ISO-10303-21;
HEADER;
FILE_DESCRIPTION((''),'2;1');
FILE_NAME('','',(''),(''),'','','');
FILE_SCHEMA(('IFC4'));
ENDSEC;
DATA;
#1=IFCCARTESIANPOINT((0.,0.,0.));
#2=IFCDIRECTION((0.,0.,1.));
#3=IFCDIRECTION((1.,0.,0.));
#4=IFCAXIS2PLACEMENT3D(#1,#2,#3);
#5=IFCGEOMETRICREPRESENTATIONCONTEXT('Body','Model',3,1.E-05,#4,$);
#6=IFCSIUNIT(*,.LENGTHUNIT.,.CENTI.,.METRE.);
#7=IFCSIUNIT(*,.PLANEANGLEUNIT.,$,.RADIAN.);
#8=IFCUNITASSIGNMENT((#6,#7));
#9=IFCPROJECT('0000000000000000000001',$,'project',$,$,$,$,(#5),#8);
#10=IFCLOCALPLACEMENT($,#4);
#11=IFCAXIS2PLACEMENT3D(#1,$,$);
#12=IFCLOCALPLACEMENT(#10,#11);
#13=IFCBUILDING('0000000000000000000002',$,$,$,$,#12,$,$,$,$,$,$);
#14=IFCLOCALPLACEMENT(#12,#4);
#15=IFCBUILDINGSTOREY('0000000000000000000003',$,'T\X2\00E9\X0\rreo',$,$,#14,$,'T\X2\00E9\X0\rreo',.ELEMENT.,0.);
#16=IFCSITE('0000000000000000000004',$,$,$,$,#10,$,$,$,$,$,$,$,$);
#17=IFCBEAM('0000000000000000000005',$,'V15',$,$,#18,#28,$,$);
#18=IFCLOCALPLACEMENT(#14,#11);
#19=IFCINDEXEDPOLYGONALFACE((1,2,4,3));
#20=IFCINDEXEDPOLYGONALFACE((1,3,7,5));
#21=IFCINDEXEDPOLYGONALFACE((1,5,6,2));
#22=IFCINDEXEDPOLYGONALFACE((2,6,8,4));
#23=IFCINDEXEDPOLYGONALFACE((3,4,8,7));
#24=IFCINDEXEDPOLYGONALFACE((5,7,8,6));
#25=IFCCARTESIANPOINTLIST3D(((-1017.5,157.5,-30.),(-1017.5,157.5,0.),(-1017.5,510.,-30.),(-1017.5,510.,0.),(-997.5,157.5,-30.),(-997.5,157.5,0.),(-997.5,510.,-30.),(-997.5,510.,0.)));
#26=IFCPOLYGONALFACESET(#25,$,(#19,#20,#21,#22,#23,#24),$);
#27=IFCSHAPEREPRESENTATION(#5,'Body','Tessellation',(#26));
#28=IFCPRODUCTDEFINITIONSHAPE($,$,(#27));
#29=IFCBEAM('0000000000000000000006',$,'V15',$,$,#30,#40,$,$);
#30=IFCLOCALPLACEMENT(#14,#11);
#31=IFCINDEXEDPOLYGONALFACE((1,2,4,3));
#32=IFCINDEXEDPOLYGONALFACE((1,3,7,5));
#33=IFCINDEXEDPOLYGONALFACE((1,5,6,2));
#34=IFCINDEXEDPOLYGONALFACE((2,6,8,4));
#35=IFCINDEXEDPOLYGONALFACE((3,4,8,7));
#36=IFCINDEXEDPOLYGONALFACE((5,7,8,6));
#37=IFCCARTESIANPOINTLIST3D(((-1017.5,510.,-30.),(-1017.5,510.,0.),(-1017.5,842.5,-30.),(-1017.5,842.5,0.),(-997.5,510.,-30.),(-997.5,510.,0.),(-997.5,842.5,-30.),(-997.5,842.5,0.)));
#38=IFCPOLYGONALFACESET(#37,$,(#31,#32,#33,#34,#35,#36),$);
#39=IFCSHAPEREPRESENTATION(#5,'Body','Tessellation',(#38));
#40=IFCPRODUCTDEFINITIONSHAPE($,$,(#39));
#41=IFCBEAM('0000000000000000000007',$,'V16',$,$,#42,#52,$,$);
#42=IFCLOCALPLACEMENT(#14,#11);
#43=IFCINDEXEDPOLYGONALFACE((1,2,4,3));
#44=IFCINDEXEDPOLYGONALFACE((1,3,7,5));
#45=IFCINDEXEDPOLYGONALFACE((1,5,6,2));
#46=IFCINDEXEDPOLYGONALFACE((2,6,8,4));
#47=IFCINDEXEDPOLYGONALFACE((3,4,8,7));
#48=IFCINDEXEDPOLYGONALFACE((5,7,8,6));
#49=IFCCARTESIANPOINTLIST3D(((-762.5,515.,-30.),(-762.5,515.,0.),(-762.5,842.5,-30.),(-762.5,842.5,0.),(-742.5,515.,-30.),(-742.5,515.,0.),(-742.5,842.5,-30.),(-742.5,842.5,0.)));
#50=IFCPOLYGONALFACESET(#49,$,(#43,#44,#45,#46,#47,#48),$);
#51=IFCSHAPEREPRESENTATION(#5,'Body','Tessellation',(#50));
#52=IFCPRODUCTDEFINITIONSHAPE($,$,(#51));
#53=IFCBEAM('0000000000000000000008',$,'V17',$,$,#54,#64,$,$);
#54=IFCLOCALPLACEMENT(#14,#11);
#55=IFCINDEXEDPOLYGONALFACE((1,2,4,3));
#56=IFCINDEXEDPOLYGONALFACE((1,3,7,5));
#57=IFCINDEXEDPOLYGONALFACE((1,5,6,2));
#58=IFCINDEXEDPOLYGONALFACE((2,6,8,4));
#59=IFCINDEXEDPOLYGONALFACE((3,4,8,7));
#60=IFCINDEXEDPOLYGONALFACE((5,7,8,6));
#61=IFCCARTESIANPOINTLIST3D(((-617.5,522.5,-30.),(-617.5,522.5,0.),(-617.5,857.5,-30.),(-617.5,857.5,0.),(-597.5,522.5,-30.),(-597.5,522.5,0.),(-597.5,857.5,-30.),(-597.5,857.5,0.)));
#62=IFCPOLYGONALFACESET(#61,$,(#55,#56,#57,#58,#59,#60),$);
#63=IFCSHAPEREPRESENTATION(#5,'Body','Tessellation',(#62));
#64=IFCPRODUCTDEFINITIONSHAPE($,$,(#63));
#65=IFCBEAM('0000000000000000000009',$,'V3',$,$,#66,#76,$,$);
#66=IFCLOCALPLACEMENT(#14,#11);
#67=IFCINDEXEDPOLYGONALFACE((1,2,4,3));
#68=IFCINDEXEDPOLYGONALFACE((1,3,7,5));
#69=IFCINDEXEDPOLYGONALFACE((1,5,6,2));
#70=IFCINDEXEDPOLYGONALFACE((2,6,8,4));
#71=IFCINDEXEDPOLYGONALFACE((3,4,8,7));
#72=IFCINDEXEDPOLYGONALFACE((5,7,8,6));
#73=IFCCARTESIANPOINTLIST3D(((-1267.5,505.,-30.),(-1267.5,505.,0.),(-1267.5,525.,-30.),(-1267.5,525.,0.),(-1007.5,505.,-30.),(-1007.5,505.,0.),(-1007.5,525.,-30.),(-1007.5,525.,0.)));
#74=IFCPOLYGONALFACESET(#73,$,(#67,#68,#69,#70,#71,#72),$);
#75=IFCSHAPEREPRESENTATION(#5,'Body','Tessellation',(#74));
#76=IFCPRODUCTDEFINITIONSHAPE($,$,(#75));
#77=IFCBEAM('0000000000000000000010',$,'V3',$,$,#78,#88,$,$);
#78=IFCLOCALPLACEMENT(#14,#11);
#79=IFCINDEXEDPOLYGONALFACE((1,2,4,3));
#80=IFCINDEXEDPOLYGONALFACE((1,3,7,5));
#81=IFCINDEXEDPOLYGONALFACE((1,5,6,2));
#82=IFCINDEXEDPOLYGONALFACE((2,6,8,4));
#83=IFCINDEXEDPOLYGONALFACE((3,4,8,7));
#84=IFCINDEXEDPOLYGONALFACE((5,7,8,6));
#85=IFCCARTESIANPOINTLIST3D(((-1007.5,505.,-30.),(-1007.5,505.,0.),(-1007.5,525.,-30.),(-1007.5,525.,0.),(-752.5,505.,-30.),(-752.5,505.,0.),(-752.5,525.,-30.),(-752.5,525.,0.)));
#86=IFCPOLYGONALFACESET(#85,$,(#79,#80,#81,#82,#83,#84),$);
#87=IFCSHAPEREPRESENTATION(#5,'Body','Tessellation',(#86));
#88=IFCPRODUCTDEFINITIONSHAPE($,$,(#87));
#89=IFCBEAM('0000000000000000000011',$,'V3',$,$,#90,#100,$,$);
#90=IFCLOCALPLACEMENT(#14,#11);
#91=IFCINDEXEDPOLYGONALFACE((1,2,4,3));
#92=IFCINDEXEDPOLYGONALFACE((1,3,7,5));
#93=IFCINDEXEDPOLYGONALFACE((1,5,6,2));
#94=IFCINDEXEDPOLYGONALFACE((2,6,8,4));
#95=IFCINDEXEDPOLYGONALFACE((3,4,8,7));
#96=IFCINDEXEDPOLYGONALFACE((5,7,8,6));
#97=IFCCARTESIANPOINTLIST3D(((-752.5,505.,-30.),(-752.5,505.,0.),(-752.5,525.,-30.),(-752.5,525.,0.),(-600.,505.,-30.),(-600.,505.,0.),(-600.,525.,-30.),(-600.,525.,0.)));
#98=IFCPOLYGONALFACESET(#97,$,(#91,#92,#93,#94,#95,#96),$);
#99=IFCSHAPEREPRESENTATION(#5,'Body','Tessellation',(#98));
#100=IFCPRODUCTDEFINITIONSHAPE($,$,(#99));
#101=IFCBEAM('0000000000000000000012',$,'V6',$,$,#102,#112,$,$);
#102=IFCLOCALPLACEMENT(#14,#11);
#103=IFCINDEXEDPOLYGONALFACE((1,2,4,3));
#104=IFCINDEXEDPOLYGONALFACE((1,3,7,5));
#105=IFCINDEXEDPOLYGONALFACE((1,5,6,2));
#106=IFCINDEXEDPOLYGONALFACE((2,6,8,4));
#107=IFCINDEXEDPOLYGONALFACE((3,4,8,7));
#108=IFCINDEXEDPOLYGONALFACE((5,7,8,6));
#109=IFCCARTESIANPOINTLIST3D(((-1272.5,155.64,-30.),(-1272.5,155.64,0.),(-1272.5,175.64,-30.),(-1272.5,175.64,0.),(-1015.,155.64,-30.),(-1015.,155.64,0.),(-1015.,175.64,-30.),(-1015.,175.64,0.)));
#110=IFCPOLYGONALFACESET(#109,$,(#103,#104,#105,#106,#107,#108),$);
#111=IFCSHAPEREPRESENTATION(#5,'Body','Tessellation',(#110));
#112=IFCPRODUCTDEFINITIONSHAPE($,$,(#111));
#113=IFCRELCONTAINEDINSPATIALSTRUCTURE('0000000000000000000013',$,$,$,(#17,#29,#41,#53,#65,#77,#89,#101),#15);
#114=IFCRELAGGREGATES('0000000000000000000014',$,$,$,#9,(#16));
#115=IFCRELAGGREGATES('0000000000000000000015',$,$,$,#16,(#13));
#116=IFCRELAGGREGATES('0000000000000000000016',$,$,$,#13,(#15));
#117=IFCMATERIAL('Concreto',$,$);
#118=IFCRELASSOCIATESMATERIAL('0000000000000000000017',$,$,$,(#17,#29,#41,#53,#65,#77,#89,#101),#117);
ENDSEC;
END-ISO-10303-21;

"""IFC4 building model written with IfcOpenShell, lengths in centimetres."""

from ifc_helpers import new_model, si_unit, frame, origin, origin_with_axes, origin_2d_with_axis, place, context, project, spatial, rectangle, extrude, material, element, save


model = new_model("IFC4")

# Units and contexts
model_context = context("Model", 3, precision=1e-05, world=origin_with_axes(), identifier="Body")
ifc_project = project(units=[si_unit("LENGTHUNIT", "METRE", prefix="CENTI"), si_unit("PLANEANGLEUNIT", "RADIAN")], contexts=[model_context])

# Site, building, storey
site_placement = place(None, origin_with_axes())
site = spatial("IfcSite", under=ifc_project, at=site_placement)
building_placement = place(site_placement, origin())
building = spatial("IfcBuilding", under=site, at=building_placement)
storey_placement = place(building_placement, origin_with_axes())
storey = spatial("IfcBuildingStorey", under=building, at=storey_placement, Name="Térreo", LongName="Térreo", CompositionType="ELEMENT", Elevation=0.0)

# Shared definitions
ifc_material = material(Name="Concreto")

# Beams
beam_1_placement = place(storey_placement, frame((-1007.5, 333.75, 0.0), z_axis=(0.0, 0.0, 1.0), x_axis=(1.0, 0.0, 0.0)))
element("IfcBeam", 1, at=beam_1_placement, inside=storey, material=ifc_material, Name="V15", context=model_context, shape_type="SolidModel", body=[
    extrude(rectangle(XDim=20.0, YDim=30.0, at=origin_2d_with_axis()), frame((0.0, -176.25, -15.0), z_axis=(0.0, 1.0, 0.0), x_axis=(-1.0, 0.0, 0.0)), (0.0, 0.0, 1.0), 352.5),
])
beam_2_placement = place(storey_placement, frame((-1007.5, 676.25, 0.0), z_axis=(0.0, 0.0, 1.0), x_axis=(1.0, 0.0, 0.0)))
element("IfcBeam", 2, at=beam_2_placement, inside=storey, material=ifc_material, Name="V15", context=model_context, shape_type="SolidModel", body=[
    extrude(rectangle(XDim=20.0, YDim=30.0, at=origin_2d_with_axis()), frame((0.0, -166.25, -15.0), z_axis=(0.0, 1.0, 0.0), x_axis=(-1.0, 0.0, 0.0)), (0.0, 0.0, 1.0), 332.5),
])
beam_3_placement = place(storey_placement, frame((-752.5, 678.75, 0.0), z_axis=(0.0, 0.0, 1.0), x_axis=(1.0, 0.0, 0.0)))
element("IfcBeam", 3, at=beam_3_placement, inside=storey, material=ifc_material, Name="V16", context=model_context, shape_type="SolidModel", body=[
    extrude(rectangle(XDim=20.0, YDim=30.0, at=origin_2d_with_axis()), frame((0.0, -163.75, -15.0), z_axis=(0.0, 1.0, 0.0), x_axis=(-1.0, 0.0, 0.0)), (0.0, 0.0, 1.0), 327.5),
])
beam_4_placement = place(storey_placement, frame((-607.5, 690.0, 0.0), z_axis=(0.0, 0.0, 1.0), x_axis=(1.0, 0.0, 0.0)))
element("IfcBeam", 4, at=beam_4_placement, inside=storey, material=ifc_material, Name="V17", context=model_context, shape_type="SolidModel", body=[
    extrude(rectangle(XDim=20.0, YDim=30.0, at=origin_2d_with_axis()), frame((0.0, -167.5, -15.0), z_axis=(0.0, 1.0, 0.0), x_axis=(-1.0, 0.0, 0.0)), (0.0, 0.0, 1.0), 335.0),
])
beam_5_placement = place(storey_placement, frame((-1137.5, 515.0, 0.0), z_axis=(0.0, 0.0, 1.0), x_axis=(1.0, 0.0, 0.0)))
element("IfcBeam", 5, at=beam_5_placement, inside=storey, material=ifc_material, Name="V3", context=model_context, shape_type="SolidModel", body=[
    extrude(rectangle(XDim=20.0, YDim=30.0, at=origin_2d_with_axis()), frame((-130.0, 0.0, -15.0), z_axis=(1.0, 0.0, 0.0), x_axis=(0.0, -1.0, 0.0)), (0.0, 0.0, 1.0), 260.0),
])
beam_6_placement = place(storey_placement, frame((-880.0, 515.0, 0.0), z_axis=(0.0, 0.0, 1.0), x_axis=(1.0, 0.0, 0.0)))
element("IfcBeam", 6, at=beam_6_placement, inside=storey, material=ifc_material, Name="V3", context=model_context, shape_type="SolidModel", body=[
    extrude(rectangle(XDim=20.0, YDim=30.0, at=origin_2d_with_axis()), frame((-127.5, 0.0, -15.0), z_axis=(1.0, 0.0, 0.0), x_axis=(0.0, -1.0, 0.0)), (0.0, 0.0, 1.0), 255.0),
])
beam_7_placement = place(storey_placement, frame((-676.25, 515.0, 0.0), z_axis=(0.0, 0.0, 1.0), x_axis=(1.0, 0.0, 0.0)))
element("IfcBeam", 7, at=beam_7_placement, inside=storey, material=ifc_material, Name="V3", context=model_context, shape_type="SolidModel", body=[
    extrude(rectangle(XDim=20.0, YDim=30.0, at=origin_2d_with_axis()), frame((-76.25, 0.0, -15.0), z_axis=(1.0, 0.0, 0.0), x_axis=(0.0, 1.0, 0.0)), (0.0, 0.0, 1.0), 152.5),
])
beam_8_placement = place(storey_placement, frame((-1143.75, 165.64, 0.0), z_axis=(0.0, 0.0, 1.0), x_axis=(1.0, 0.0, 0.0)))
element("IfcBeam", 8, at=beam_8_placement, inside=storey, material=ifc_material, Name="V6", context=model_context, shape_type="SolidModel", body=[
    extrude(rectangle(XDim=20.0, YDim=30.0, at=origin_2d_with_axis()), frame((-128.75, 0.0, -15.0), z_axis=(1.0, 0.0, 0.0), x_axis=(0.0, -1.0, 0.0)), (0.0, 0.0, 1.0), 257.5),
])

save(model, "model.ifc")
